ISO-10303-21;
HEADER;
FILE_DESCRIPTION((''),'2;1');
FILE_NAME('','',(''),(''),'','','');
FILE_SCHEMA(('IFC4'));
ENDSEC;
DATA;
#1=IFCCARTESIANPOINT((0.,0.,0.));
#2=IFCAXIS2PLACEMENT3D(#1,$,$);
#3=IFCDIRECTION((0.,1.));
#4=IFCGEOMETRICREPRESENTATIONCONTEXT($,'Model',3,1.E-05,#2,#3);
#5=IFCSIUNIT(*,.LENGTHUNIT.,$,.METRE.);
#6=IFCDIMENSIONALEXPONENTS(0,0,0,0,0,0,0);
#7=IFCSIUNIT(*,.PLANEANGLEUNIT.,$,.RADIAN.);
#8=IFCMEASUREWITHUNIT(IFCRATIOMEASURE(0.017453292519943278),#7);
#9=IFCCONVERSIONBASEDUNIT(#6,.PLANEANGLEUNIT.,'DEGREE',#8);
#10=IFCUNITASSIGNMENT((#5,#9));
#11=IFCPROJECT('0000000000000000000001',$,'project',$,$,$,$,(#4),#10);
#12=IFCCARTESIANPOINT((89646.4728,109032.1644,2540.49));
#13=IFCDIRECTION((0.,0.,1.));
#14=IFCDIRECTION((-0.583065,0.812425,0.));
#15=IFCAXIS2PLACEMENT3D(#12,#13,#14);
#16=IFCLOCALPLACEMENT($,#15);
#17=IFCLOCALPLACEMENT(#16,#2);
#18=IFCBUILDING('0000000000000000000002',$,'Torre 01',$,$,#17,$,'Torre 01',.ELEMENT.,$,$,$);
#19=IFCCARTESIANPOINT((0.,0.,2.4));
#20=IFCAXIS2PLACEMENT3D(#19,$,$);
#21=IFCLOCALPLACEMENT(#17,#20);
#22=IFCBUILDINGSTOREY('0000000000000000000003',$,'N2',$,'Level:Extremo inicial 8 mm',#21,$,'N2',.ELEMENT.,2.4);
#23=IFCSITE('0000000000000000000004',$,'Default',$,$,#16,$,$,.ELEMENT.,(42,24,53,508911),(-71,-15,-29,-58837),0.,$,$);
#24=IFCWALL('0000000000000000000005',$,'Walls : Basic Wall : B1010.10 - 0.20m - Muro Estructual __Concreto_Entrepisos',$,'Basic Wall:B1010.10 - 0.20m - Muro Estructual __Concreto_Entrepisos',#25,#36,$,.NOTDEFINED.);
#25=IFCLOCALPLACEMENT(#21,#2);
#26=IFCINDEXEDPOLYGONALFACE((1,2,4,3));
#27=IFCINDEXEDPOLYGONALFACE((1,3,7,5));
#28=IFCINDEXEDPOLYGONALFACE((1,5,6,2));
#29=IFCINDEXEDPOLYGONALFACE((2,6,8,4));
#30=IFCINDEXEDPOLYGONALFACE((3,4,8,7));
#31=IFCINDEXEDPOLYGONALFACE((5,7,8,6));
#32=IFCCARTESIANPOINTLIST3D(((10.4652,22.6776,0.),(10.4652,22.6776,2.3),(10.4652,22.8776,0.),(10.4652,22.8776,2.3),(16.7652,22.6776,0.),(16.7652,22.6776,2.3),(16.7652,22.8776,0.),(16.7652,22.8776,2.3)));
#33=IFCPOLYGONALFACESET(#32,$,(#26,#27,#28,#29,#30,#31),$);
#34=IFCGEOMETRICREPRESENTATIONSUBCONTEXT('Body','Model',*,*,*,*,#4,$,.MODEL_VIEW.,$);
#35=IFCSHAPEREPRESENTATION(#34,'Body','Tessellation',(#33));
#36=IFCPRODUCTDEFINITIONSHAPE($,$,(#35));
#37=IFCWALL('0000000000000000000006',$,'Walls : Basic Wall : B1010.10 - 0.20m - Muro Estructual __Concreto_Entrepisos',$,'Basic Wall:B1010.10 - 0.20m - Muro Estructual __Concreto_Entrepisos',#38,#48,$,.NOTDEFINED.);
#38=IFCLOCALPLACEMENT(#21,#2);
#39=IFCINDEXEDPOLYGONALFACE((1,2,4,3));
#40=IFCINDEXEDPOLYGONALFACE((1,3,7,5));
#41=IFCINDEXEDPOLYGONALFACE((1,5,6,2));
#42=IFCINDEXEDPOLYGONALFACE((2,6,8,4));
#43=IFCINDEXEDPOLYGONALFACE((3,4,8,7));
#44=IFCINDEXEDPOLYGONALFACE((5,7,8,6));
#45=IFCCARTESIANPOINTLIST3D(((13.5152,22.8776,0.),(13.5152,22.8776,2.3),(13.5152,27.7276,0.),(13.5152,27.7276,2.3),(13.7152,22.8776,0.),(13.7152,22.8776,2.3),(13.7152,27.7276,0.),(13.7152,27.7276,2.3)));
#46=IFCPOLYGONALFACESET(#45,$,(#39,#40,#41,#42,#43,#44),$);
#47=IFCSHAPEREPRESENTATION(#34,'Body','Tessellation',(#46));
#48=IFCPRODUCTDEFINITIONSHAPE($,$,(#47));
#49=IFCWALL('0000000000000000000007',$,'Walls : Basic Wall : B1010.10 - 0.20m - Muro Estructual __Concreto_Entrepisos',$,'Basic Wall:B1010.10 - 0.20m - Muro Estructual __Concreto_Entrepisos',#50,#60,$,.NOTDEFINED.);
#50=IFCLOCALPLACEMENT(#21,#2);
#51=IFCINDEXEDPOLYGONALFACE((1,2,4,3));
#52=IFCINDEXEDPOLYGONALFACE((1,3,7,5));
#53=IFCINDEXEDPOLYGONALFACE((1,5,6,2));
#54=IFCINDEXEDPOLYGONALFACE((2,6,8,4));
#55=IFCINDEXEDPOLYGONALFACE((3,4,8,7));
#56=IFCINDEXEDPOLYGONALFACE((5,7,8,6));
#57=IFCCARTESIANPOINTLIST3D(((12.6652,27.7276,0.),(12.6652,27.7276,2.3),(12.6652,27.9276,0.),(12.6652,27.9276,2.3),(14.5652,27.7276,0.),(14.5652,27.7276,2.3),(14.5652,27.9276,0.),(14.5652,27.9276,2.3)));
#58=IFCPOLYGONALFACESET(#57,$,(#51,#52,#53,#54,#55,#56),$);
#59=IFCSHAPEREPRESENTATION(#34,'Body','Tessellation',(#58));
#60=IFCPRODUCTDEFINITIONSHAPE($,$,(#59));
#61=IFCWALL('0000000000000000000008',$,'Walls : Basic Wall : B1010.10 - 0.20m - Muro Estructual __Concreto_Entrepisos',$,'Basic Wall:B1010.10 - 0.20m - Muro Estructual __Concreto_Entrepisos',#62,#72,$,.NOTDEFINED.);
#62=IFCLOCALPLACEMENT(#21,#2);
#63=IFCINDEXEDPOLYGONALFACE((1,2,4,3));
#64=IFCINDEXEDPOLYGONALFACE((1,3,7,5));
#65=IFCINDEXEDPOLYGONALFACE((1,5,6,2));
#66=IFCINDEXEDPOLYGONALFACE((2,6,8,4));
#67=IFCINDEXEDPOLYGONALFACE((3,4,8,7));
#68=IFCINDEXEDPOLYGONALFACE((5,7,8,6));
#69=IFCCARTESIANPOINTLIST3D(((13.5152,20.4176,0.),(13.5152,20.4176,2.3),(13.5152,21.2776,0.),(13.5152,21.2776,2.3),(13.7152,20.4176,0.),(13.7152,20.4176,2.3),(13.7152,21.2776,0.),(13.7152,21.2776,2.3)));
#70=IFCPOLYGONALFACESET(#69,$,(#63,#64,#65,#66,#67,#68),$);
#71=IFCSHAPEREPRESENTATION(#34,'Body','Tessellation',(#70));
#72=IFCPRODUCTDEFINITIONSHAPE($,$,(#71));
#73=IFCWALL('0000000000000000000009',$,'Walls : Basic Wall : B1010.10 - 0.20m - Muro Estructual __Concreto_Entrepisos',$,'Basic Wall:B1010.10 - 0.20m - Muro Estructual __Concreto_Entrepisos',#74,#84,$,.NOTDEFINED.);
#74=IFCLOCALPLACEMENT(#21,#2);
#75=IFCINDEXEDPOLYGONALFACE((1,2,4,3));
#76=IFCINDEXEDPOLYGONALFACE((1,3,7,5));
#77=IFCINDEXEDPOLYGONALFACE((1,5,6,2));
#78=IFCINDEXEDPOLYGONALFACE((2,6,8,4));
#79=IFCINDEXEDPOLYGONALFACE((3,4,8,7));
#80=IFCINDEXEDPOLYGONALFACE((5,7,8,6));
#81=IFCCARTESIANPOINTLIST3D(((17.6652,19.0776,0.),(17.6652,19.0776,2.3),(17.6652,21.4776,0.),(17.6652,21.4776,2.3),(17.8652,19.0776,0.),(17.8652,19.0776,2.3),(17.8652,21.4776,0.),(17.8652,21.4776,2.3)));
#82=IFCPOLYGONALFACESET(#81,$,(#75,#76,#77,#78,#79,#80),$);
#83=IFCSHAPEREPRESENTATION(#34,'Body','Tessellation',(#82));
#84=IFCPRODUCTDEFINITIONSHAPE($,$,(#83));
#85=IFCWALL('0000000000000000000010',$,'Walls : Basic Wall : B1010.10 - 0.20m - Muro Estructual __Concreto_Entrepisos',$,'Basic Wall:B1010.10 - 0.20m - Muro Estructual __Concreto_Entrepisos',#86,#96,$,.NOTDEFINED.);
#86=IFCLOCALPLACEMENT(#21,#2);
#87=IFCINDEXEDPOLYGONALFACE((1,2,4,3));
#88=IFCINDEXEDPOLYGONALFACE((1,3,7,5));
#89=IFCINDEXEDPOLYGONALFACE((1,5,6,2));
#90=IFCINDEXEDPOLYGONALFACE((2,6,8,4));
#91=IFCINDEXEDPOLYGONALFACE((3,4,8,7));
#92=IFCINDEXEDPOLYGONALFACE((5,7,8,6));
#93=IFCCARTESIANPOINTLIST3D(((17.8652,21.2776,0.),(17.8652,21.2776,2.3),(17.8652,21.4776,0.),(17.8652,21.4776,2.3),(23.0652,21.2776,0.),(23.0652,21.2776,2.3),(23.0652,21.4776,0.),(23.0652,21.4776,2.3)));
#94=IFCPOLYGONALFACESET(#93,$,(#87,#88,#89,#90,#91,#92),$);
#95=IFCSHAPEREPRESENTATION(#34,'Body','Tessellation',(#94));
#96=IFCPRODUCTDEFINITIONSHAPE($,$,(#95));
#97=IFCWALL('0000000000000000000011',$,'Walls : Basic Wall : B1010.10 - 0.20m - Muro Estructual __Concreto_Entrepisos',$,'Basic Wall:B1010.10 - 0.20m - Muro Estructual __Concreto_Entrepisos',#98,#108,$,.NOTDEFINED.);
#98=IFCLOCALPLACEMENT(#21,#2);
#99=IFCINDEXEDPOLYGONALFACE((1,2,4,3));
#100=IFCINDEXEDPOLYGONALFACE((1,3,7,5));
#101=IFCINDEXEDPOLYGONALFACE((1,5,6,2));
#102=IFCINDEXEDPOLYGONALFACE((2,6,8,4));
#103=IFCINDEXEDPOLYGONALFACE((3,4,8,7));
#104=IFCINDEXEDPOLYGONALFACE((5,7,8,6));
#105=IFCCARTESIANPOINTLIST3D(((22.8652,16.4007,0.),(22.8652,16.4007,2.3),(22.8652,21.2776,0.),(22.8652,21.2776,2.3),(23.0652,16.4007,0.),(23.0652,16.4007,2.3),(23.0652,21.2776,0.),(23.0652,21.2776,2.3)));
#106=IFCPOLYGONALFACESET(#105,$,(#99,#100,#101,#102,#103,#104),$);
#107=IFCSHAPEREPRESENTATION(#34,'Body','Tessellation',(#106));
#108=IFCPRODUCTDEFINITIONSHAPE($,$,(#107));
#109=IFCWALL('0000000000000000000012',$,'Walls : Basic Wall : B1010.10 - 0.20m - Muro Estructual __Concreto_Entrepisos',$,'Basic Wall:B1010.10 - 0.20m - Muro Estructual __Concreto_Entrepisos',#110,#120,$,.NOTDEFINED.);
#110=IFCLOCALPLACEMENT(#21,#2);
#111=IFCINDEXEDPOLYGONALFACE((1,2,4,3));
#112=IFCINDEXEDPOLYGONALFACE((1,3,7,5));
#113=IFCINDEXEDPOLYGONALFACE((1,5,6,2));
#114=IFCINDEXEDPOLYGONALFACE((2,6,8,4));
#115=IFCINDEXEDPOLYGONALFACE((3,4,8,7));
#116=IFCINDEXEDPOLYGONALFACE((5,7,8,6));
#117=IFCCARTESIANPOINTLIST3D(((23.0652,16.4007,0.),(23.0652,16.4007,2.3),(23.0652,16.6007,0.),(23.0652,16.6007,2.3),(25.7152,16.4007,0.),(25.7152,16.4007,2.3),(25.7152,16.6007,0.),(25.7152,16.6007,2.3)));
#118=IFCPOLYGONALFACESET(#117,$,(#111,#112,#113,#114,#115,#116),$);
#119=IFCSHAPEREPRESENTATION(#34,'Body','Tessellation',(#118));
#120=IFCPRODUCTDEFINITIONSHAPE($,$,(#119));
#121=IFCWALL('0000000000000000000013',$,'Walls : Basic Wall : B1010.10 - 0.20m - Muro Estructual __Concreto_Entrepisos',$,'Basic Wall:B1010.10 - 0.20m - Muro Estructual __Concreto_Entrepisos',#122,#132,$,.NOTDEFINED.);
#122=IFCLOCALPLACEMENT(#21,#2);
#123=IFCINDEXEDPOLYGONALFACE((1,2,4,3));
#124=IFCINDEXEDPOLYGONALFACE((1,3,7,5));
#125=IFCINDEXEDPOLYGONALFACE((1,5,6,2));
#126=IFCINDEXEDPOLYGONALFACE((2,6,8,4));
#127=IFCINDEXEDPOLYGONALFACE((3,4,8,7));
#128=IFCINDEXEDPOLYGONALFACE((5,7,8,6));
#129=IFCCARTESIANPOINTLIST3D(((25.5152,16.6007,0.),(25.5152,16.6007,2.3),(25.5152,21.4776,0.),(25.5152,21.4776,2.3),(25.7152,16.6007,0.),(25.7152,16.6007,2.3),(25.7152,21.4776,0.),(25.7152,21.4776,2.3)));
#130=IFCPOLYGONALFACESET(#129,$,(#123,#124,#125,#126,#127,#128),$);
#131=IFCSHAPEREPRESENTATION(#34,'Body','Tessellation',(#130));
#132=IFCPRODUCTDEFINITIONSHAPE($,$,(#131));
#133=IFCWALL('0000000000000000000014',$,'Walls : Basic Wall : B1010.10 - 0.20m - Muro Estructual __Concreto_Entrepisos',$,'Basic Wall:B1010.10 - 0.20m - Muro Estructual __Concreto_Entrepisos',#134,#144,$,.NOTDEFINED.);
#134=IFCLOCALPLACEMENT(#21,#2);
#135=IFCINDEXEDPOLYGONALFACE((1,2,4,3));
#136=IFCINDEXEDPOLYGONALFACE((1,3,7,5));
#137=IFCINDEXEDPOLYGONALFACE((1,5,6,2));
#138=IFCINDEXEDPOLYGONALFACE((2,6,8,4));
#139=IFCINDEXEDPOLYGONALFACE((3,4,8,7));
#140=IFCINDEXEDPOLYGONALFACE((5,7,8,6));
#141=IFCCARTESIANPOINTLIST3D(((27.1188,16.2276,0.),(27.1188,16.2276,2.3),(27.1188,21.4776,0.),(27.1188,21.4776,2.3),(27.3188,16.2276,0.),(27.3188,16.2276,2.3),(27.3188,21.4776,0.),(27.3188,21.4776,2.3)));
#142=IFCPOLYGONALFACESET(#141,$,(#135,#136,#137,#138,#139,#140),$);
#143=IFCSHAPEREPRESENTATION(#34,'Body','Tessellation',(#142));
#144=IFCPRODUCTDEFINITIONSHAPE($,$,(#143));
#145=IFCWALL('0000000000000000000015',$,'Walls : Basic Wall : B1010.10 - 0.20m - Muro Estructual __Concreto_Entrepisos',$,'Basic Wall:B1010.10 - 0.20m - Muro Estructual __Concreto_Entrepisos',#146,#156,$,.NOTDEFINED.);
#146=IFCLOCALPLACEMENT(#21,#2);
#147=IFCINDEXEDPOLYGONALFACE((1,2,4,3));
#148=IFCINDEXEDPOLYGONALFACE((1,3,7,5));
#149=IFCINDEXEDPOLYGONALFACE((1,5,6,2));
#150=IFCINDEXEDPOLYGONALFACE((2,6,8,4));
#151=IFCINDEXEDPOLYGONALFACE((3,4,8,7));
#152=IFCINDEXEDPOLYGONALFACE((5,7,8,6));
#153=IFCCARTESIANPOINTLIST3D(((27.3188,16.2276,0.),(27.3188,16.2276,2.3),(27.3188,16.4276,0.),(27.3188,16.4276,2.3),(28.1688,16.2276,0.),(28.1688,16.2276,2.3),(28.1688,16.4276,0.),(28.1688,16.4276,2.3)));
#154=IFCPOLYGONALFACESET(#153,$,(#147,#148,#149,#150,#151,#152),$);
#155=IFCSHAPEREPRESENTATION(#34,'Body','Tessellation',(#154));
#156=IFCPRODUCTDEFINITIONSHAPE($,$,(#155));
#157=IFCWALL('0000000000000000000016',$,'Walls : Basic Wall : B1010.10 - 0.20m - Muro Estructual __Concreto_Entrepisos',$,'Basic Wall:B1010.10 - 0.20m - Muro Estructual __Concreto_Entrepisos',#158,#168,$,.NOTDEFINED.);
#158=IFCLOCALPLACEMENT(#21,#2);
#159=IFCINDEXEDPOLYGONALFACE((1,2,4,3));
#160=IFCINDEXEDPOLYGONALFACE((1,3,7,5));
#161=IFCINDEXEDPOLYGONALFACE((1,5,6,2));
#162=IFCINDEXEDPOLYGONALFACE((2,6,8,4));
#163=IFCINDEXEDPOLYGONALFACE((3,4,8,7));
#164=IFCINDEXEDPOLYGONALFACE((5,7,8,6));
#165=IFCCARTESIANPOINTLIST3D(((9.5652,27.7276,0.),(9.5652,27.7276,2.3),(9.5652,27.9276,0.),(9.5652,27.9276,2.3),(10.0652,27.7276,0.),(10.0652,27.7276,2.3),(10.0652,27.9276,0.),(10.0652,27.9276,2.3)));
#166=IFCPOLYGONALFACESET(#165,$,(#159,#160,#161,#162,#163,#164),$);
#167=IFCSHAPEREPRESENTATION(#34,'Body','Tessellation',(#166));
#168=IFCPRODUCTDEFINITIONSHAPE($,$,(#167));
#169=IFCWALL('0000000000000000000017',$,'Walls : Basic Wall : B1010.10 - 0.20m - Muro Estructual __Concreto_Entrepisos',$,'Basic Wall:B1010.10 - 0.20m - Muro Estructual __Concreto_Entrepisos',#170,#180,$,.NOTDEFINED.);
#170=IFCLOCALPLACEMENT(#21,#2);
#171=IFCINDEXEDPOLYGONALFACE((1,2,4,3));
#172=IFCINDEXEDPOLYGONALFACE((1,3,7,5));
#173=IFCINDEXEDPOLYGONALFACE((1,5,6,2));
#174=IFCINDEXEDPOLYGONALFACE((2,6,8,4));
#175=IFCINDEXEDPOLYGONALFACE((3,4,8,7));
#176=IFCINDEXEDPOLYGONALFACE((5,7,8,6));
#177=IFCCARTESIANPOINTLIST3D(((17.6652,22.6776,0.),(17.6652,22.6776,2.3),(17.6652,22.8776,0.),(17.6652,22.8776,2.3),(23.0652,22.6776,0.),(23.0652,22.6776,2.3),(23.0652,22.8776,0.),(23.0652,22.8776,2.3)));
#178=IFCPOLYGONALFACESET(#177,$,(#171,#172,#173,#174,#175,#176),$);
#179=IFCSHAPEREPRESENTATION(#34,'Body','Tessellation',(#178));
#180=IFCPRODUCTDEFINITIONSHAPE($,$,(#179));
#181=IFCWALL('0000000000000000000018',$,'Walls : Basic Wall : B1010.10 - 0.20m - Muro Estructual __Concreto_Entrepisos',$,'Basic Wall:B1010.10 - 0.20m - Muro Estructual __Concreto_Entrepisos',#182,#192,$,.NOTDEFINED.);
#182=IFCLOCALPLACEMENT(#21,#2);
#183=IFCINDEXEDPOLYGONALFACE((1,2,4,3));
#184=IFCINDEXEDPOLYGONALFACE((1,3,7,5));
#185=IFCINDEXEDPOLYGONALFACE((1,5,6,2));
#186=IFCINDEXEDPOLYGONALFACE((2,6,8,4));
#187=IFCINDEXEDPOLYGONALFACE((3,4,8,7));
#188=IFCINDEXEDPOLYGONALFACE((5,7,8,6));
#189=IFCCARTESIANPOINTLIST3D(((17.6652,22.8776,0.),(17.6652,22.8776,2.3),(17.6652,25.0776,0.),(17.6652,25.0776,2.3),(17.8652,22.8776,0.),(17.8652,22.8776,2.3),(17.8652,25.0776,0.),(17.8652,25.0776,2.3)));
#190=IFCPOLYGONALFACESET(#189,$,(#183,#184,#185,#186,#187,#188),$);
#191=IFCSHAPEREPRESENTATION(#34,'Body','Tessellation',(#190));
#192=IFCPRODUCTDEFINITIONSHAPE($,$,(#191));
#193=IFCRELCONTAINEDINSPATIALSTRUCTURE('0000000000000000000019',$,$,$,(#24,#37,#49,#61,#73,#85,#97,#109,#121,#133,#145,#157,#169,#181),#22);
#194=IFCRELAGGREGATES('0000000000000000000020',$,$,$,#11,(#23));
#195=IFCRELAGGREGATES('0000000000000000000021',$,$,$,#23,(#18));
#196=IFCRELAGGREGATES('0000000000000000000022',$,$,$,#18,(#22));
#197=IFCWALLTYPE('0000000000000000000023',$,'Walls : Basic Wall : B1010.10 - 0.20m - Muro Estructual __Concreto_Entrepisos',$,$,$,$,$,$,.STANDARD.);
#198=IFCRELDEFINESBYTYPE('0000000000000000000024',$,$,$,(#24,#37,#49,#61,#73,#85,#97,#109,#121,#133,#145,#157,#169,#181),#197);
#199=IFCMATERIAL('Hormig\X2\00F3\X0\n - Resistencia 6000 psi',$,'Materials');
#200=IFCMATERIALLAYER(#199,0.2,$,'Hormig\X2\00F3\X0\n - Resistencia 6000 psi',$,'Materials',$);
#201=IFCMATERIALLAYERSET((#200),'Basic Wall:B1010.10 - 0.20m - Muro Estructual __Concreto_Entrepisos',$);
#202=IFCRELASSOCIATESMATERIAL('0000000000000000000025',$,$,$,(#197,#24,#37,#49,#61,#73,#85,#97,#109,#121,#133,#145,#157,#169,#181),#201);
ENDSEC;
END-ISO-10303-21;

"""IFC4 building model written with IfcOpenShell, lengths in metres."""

from ifc_helpers import new_model, entity, si_unit, converted_unit, direction, frame, frame_2d, origin, place, context, subcontext, project, spatial, rectangle, extrude, material, layer, layer_set, layer_usage, type_object, element, save


model = new_model("IFC4")

# Units and contexts
model_context = context("Model", 3, precision=1e-05, world=origin(), true_north=direction((0.0, 1.0)))
body_context = subcontext(model_context, "Body", "Model", "MODEL_VIEW")
ifc_project = project(units=[si_unit("LENGTHUNIT", "METRE"), converted_unit("PLANEANGLEUNIT", "DEGREE", entity("IfcRatioMeasure", 0.017453292519943278), si_unit("PLANEANGLEUNIT", "RADIAN"), dimensions=[0, 0, 0, 0, 0, 0, 0])], contexts=[model_context])

# Site, building, storey
site_placement = place(None, frame((89646.4728, 109032.1644, 2540.49), z_axis=(0.0, 0.0, 1.0), x_axis=(-0.583065, 0.812425, 0.0)))
site = spatial("IfcSite", under=ifc_project, at=site_placement, Name="Default", CompositionType="ELEMENT", RefLatitude=(42, 24, 53, 508911), RefLongitude=(-71, -15, -29, -58837), RefElevation=0.0)
building_placement = place(site_placement, origin())
building = spatial("IfcBuilding", under=site, at=building_placement, Name="Torre 01", LongName="Torre 01", CompositionType="ELEMENT")
storey_placement = place(building_placement, frame((0.0, 0.0, 2.4)))
storey = spatial("IfcBuildingStorey", under=building, at=storey_placement, Name="N2", ObjectType="Level:Extremo inicial 8 mm", LongName="N2", CompositionType="ELEMENT", Elevation=2.4)

# Walls
ifc_material = material(Name="Hormigón - Resistencia 6000 psi", Category="Materials")
ifc_layer_1 = layer(ifc_material, 0.2, Name="Hormigón - Resistencia 6000 psi", Category="Materials")
ifc_layer_set_1 = layer_set([ifc_layer_1], Name="Basic Wall:B1010.10 - 0.20m - Muro Estructual __Concreto_Entrepisos")
ifc_layer_usage_1 = layer_usage(ifc_layer_set_1, "AXIS2", "NEGATIVE", 0.1)
wall_type_1 = type_object("IfcWallType", Name="Walls : Basic Wall : B1010.10 - 0.20m - Muro Estructual __Concreto_Entrepisos", PredefinedType="STANDARD", material=ifc_layer_set_1)
wall_1_placement = place(storey_placement, frame((10.4652, 22.7776, 0.0)))
element("IfcWall", 1, at=wall_1_placement, inside=storey, type_object=wall_type_1, material=ifc_layer_usage_1, Name="Walls : Basic Wall : B1010.10 - 0.20m - Muro Estructual __Concreto_Entrepisos", ObjectType="Basic Wall:B1010.10 - 0.20m - Muro Estructual __Concreto_Entrepisos", PredefinedType="NOTDEFINED", context=body_context, shape_type="SweptSolid", body=[
    extrude(rectangle(XDim=6.3, YDim=0.2, at=frame_2d((3.15, 0.0), x_axis=(-1.0, 0.0))), origin(), (0.0, 0.0, 1.0), 2.3),
])
ifc_layer_usage_2 = layer_usage(ifc_layer_set_1, "AXIS2", "NEGATIVE", 0.1)
wall_2_placement = place(storey_placement, frame((13.6152, 22.8776, 0.0), z_axis=(0.0, 0.0, 1.0), x_axis=(0.0, 1.0, 0.0)))
element("IfcWall", 2, at=wall_2_placement, inside=storey, type_object=wall_type_1, material=ifc_layer_usage_2, Name="Walls : Basic Wall : B1010.10 - 0.20m - Muro Estructual __Concreto_Entrepisos", ObjectType="Basic Wall:B1010.10 - 0.20m - Muro Estructual __Concreto_Entrepisos", PredefinedType="NOTDEFINED", context=body_context, shape_type="SweptSolid", body=[
    extrude(rectangle(XDim=4.85, YDim=0.2, at=frame_2d((2.425, 0.0), x_axis=(-1.0, 0.0))), origin(), (0.0, 0.0, 1.0), 2.3),
])
ifc_layer_usage_3 = layer_usage(ifc_layer_set_1, "AXIS2", "NEGATIVE", 0.1)
wall_3_placement = place(storey_placement, frame((12.6652, 27.8276, 0.0)))
element("IfcWall", 3, at=wall_3_placement, inside=storey, type_object=wall_type_1, material=ifc_layer_usage_3, Name="Walls : Basic Wall : B1010.10 - 0.20m - Muro Estructual __Concreto_Entrepisos", ObjectType="Basic Wall:B1010.10 - 0.20m - Muro Estructual __Concreto_Entrepisos", PredefinedType="NOTDEFINED", context=body_context, shape_type="SweptSolid", body=[
    extrude(rectangle(XDim=1.9, YDim=0.2, at=frame_2d((0.95, 0.0), x_axis=(-1.0, 0.0))), origin(), (0.0, 0.0, 1.0), 2.3),
])
ifc_layer_usage_4 = layer_usage(ifc_layer_set_1, "AXIS2", "NEGATIVE", 0.1)
wall_4_placement = place(storey_placement, frame((13.6152, 21.2776, 0.0), z_axis=(0.0, 0.0, 1.0), x_axis=(0.0, -1.0, 0.0)))
element("IfcWall", 4, at=wall_4_placement, inside=storey, type_object=wall_type_1, material=ifc_layer_usage_4, Name="Walls : Basic Wall : B1010.10 - 0.20m - Muro Estructual __Concreto_Entrepisos", ObjectType="Basic Wall:B1010.10 - 0.20m - Muro Estructual __Concreto_Entrepisos", PredefinedType="NOTDEFINED", context=body_context, shape_type="SweptSolid", body=[
    extrude(rectangle(XDim=0.86, YDim=0.2, at=frame_2d((0.43, 0.0), x_axis=(-1.0, 0.0))), origin(), (0.0, 0.0, 1.0), 2.3),
])
ifc_layer_usage_5 = layer_usage(ifc_layer_set_1, "AXIS2", "NEGATIVE", 0.1)
wall_5_placement = place(storey_placement, frame((17.7652, 19.0776, 0.0), z_axis=(0.0, 0.0, 1.0), x_axis=(0.0, 1.0, 0.0)))
element("IfcWall", 5, at=wall_5_placement, inside=storey, type_object=wall_type_1, material=ifc_layer_usage_5, Name="Walls : Basic Wall : B1010.10 - 0.20m - Muro Estructual __Concreto_Entrepisos", ObjectType="Basic Wall:B1010.10 - 0.20m - Muro Estructual __Concreto_Entrepisos", PredefinedType="NOTDEFINED", context=body_context, shape_type="SweptSolid", body=[
    extrude(rectangle(XDim=2.4, YDim=0.2, at=frame_2d((1.2, 0.0), x_axis=(-1.0, 0.0))), origin(), (0.0, 0.0, 1.0), 2.3),
])
ifc_layer_usage_6 = layer_usage(ifc_layer_set_1, "AXIS2", "NEGATIVE", 0.1)
wall_6_placement = place(storey_placement, frame((17.8652, 21.3776, 0.0)))
element("IfcWall", 6, at=wall_6_placement, inside=storey, type_object=wall_type_1, material=ifc_layer_usage_6, Name="Walls : Basic Wall : B1010.10 - 0.20m - Muro Estructual __Concreto_Entrepisos", ObjectType="Basic Wall:B1010.10 - 0.20m - Muro Estructual __Concreto_Entrepisos", PredefinedType="NOTDEFINED", context=body_context, shape_type="SweptSolid", body=[
    extrude(rectangle(XDim=5.2, YDim=0.2, at=frame_2d((2.6, 0.0), x_axis=(-1.0, 0.0))), origin(), (0.0, 0.0, 1.0), 2.3),
])
ifc_layer_usage_7 = layer_usage(ifc_layer_set_1, "AXIS2", "NEGATIVE", 0.1)
wall_7_placement = place(storey_placement, frame((22.9652, 21.2776, 0.0), z_axis=(0.0, 0.0, 1.0), x_axis=(0.0, -1.0, 0.0)))
element("IfcWall", 7, at=wall_7_placement, inside=storey, type_object=wall_type_1, material=ifc_layer_usage_7, Name="Walls : Basic Wall : B1010.10 - 0.20m - Muro Estructual __Concreto_Entrepisos", ObjectType="Basic Wall:B1010.10 - 0.20m - Muro Estructual __Concreto_Entrepisos", PredefinedType="NOTDEFINED", context=body_context, shape_type="SweptSolid", body=[
    extrude(rectangle(XDim=4.8769, YDim=0.2, at=frame_2d((2.4384, 0.0), x_axis=(-1.0, 0.0))), origin(), (0.0, 0.0, 1.0), 2.3),
])
ifc_layer_usage_8 = layer_usage(ifc_layer_set_1, "AXIS2", "NEGATIVE", 0.1)
wall_8_placement = place(storey_placement, frame((23.0652, 16.5007, 0.0)))
element("IfcWall", 8, at=wall_8_placement, inside=storey, type_object=wall_type_1, material=ifc_layer_usage_8, Name="Walls : Basic Wall : B1010.10 - 0.20m - Muro Estructual __Concreto_Entrepisos", ObjectType="Basic Wall:B1010.10 - 0.20m - Muro Estructual __Concreto_Entrepisos", PredefinedType="NOTDEFINED", context=body_context, shape_type="SweptSolid", body=[
    extrude(rectangle(XDim=2.65, YDim=0.2, at=frame_2d((1.325, 0.0), x_axis=(-1.0, 0.0))), origin(), (0.0, 0.0, 1.0), 2.3),
])
ifc_layer_usage_9 = layer_usage(ifc_layer_set_1, "AXIS2", "NEGATIVE", 0.1)
wall_9_placement = place(storey_placement, frame((25.6152, 16.6007, 0.0), z_axis=(0.0, 0.0, 1.0), x_axis=(0.0, 1.0, 0.0)))
element("IfcWall", 9, at=wall_9_placement, inside=storey, type_object=wall_type_1, material=ifc_layer_usage_9, Name="Walls : Basic Wall : B1010.10 - 0.20m - Muro Estructual __Concreto_Entrepisos", ObjectType="Basic Wall:B1010.10 - 0.20m - Muro Estructual __Concreto_Entrepisos", PredefinedType="NOTDEFINED", context=body_context, shape_type="SweptSolid", body=[
    extrude(rectangle(XDim=4.8769, YDim=0.2, at=frame_2d((2.4384, 0.0), x_axis=(-1.0, 0.0))), origin(), (0.0, 0.0, 1.0), 2.3),
])
ifc_layer_usage_10 = layer_usage(ifc_layer_set_1, "AXIS2", "NEGATIVE", 0.1)
wall_10_placement = place(storey_placement, frame((27.2188, 16.2276, 0.0), z_axis=(0.0, 0.0, 1.0), x_axis=(0.0, 1.0, 0.0)))
element("IfcWall", 10, at=wall_10_placement, inside=storey, type_object=wall_type_1, material=ifc_layer_usage_10, Name="Walls : Basic Wall : B1010.10 - 0.20m - Muro Estructual __Concreto_Entrepisos", ObjectType="Basic Wall:B1010.10 - 0.20m - Muro Estructual __Concreto_Entrepisos", PredefinedType="NOTDEFINED", context=body_context, shape_type="SweptSolid", body=[
    extrude(rectangle(XDim=5.25, YDim=0.2, at=frame_2d((2.625, 0.0), x_axis=(-1.0, 0.0))), origin(), (0.0, 0.0, 1.0), 2.3),
])
ifc_layer_usage_11 = layer_usage(ifc_layer_set_1, "AXIS2", "NEGATIVE", 0.1)
wall_11_placement = place(storey_placement, frame((27.3188, 16.3276, 0.0)))
element("IfcWall", 11, at=wall_11_placement, inside=storey, type_object=wall_type_1, material=ifc_layer_usage_11, Name="Walls : Basic Wall : B1010.10 - 0.20m - Muro Estructual __Concreto_Entrepisos", ObjectType="Basic Wall:B1010.10 - 0.20m - Muro Estructual __Concreto_Entrepisos", PredefinedType="NOTDEFINED", context=body_context, shape_type="SweptSolid", body=[
    extrude(rectangle(XDim=0.85, YDim=0.2, at=frame_2d((0.425, 0.0), x_axis=(-1.0, 0.0))), origin(), (0.0, 0.0, 1.0), 2.3),
])
ifc_layer_usage_12 = layer_usage(ifc_layer_set_1, "AXIS2", "NEGATIVE", 0.1)
wall_12_placement = place(storey_placement, frame((9.5652, 27.8276, 0.0)))
element("IfcWall", 12, at=wall_12_placement, inside=storey, type_object=wall_type_1, material=ifc_layer_usage_12, Name="Walls : Basic Wall : B1010.10 - 0.20m - Muro Estructual __Concreto_Entrepisos", ObjectType="Basic Wall:B1010.10 - 0.20m - Muro Estructual __Concreto_Entrepisos", PredefinedType="NOTDEFINED", context=body_context, shape_type="SweptSolid", body=[
    extrude(rectangle(XDim=0.5, YDim=0.2, at=frame_2d((0.25, 0.0), x_axis=(-1.0, 0.0))), origin(), (0.0, 0.0, 1.0), 2.3),
])
ifc_layer_usage_13 = layer_usage(ifc_layer_set_1, "AXIS2", "NEGATIVE", 0.1)
wall_13_placement = place(storey_placement, frame((17.6652, 22.7776, 0.0)))
element("IfcWall", 13, at=wall_13_placement, inside=storey, type_object=wall_type_1, material=ifc_layer_usage_13, Name="Walls : Basic Wall : B1010.10 - 0.20m - Muro Estructual __Concreto_Entrepisos", ObjectType="Basic Wall:B1010.10 - 0.20m - Muro Estructual __Concreto_Entrepisos", PredefinedType="NOTDEFINED", context=body_context, shape_type="SweptSolid", body=[
    extrude(rectangle(XDim=5.4, YDim=0.2, at=frame_2d((2.7, 0.0), x_axis=(-1.0, 0.0))), origin(), (0.0, 0.0, 1.0), 2.3),
])
ifc_layer_usage_14 = layer_usage(ifc_layer_set_1, "AXIS2", "NEGATIVE", 0.1)
wall_14_placement = place(storey_placement, frame((17.7652, 22.8776, 0.0), z_axis=(0.0, 0.0, 1.0), x_axis=(0.0, 1.0, 0.0)))
element("IfcWall", 14, at=wall_14_placement, inside=storey, type_object=wall_type_1, material=ifc_layer_usage_14, Name="Walls : Basic Wall : B1010.10 - 0.20m - Muro Estructual __Concreto_Entrepisos", ObjectType="Basic Wall:B1010.10 - 0.20m - Muro Estructual __Concreto_Entrepisos", PredefinedType="NOTDEFINED", context=body_context, shape_type="SweptSolid", body=[
    extrude(rectangle(XDim=2.2, YDim=0.2, at=frame_2d((1.1, 0.0), x_axis=(-1.0, 0.0))), origin(), (0.0, 0.0, 1.0), 2.3),
])

save(model, "model.ifc")
